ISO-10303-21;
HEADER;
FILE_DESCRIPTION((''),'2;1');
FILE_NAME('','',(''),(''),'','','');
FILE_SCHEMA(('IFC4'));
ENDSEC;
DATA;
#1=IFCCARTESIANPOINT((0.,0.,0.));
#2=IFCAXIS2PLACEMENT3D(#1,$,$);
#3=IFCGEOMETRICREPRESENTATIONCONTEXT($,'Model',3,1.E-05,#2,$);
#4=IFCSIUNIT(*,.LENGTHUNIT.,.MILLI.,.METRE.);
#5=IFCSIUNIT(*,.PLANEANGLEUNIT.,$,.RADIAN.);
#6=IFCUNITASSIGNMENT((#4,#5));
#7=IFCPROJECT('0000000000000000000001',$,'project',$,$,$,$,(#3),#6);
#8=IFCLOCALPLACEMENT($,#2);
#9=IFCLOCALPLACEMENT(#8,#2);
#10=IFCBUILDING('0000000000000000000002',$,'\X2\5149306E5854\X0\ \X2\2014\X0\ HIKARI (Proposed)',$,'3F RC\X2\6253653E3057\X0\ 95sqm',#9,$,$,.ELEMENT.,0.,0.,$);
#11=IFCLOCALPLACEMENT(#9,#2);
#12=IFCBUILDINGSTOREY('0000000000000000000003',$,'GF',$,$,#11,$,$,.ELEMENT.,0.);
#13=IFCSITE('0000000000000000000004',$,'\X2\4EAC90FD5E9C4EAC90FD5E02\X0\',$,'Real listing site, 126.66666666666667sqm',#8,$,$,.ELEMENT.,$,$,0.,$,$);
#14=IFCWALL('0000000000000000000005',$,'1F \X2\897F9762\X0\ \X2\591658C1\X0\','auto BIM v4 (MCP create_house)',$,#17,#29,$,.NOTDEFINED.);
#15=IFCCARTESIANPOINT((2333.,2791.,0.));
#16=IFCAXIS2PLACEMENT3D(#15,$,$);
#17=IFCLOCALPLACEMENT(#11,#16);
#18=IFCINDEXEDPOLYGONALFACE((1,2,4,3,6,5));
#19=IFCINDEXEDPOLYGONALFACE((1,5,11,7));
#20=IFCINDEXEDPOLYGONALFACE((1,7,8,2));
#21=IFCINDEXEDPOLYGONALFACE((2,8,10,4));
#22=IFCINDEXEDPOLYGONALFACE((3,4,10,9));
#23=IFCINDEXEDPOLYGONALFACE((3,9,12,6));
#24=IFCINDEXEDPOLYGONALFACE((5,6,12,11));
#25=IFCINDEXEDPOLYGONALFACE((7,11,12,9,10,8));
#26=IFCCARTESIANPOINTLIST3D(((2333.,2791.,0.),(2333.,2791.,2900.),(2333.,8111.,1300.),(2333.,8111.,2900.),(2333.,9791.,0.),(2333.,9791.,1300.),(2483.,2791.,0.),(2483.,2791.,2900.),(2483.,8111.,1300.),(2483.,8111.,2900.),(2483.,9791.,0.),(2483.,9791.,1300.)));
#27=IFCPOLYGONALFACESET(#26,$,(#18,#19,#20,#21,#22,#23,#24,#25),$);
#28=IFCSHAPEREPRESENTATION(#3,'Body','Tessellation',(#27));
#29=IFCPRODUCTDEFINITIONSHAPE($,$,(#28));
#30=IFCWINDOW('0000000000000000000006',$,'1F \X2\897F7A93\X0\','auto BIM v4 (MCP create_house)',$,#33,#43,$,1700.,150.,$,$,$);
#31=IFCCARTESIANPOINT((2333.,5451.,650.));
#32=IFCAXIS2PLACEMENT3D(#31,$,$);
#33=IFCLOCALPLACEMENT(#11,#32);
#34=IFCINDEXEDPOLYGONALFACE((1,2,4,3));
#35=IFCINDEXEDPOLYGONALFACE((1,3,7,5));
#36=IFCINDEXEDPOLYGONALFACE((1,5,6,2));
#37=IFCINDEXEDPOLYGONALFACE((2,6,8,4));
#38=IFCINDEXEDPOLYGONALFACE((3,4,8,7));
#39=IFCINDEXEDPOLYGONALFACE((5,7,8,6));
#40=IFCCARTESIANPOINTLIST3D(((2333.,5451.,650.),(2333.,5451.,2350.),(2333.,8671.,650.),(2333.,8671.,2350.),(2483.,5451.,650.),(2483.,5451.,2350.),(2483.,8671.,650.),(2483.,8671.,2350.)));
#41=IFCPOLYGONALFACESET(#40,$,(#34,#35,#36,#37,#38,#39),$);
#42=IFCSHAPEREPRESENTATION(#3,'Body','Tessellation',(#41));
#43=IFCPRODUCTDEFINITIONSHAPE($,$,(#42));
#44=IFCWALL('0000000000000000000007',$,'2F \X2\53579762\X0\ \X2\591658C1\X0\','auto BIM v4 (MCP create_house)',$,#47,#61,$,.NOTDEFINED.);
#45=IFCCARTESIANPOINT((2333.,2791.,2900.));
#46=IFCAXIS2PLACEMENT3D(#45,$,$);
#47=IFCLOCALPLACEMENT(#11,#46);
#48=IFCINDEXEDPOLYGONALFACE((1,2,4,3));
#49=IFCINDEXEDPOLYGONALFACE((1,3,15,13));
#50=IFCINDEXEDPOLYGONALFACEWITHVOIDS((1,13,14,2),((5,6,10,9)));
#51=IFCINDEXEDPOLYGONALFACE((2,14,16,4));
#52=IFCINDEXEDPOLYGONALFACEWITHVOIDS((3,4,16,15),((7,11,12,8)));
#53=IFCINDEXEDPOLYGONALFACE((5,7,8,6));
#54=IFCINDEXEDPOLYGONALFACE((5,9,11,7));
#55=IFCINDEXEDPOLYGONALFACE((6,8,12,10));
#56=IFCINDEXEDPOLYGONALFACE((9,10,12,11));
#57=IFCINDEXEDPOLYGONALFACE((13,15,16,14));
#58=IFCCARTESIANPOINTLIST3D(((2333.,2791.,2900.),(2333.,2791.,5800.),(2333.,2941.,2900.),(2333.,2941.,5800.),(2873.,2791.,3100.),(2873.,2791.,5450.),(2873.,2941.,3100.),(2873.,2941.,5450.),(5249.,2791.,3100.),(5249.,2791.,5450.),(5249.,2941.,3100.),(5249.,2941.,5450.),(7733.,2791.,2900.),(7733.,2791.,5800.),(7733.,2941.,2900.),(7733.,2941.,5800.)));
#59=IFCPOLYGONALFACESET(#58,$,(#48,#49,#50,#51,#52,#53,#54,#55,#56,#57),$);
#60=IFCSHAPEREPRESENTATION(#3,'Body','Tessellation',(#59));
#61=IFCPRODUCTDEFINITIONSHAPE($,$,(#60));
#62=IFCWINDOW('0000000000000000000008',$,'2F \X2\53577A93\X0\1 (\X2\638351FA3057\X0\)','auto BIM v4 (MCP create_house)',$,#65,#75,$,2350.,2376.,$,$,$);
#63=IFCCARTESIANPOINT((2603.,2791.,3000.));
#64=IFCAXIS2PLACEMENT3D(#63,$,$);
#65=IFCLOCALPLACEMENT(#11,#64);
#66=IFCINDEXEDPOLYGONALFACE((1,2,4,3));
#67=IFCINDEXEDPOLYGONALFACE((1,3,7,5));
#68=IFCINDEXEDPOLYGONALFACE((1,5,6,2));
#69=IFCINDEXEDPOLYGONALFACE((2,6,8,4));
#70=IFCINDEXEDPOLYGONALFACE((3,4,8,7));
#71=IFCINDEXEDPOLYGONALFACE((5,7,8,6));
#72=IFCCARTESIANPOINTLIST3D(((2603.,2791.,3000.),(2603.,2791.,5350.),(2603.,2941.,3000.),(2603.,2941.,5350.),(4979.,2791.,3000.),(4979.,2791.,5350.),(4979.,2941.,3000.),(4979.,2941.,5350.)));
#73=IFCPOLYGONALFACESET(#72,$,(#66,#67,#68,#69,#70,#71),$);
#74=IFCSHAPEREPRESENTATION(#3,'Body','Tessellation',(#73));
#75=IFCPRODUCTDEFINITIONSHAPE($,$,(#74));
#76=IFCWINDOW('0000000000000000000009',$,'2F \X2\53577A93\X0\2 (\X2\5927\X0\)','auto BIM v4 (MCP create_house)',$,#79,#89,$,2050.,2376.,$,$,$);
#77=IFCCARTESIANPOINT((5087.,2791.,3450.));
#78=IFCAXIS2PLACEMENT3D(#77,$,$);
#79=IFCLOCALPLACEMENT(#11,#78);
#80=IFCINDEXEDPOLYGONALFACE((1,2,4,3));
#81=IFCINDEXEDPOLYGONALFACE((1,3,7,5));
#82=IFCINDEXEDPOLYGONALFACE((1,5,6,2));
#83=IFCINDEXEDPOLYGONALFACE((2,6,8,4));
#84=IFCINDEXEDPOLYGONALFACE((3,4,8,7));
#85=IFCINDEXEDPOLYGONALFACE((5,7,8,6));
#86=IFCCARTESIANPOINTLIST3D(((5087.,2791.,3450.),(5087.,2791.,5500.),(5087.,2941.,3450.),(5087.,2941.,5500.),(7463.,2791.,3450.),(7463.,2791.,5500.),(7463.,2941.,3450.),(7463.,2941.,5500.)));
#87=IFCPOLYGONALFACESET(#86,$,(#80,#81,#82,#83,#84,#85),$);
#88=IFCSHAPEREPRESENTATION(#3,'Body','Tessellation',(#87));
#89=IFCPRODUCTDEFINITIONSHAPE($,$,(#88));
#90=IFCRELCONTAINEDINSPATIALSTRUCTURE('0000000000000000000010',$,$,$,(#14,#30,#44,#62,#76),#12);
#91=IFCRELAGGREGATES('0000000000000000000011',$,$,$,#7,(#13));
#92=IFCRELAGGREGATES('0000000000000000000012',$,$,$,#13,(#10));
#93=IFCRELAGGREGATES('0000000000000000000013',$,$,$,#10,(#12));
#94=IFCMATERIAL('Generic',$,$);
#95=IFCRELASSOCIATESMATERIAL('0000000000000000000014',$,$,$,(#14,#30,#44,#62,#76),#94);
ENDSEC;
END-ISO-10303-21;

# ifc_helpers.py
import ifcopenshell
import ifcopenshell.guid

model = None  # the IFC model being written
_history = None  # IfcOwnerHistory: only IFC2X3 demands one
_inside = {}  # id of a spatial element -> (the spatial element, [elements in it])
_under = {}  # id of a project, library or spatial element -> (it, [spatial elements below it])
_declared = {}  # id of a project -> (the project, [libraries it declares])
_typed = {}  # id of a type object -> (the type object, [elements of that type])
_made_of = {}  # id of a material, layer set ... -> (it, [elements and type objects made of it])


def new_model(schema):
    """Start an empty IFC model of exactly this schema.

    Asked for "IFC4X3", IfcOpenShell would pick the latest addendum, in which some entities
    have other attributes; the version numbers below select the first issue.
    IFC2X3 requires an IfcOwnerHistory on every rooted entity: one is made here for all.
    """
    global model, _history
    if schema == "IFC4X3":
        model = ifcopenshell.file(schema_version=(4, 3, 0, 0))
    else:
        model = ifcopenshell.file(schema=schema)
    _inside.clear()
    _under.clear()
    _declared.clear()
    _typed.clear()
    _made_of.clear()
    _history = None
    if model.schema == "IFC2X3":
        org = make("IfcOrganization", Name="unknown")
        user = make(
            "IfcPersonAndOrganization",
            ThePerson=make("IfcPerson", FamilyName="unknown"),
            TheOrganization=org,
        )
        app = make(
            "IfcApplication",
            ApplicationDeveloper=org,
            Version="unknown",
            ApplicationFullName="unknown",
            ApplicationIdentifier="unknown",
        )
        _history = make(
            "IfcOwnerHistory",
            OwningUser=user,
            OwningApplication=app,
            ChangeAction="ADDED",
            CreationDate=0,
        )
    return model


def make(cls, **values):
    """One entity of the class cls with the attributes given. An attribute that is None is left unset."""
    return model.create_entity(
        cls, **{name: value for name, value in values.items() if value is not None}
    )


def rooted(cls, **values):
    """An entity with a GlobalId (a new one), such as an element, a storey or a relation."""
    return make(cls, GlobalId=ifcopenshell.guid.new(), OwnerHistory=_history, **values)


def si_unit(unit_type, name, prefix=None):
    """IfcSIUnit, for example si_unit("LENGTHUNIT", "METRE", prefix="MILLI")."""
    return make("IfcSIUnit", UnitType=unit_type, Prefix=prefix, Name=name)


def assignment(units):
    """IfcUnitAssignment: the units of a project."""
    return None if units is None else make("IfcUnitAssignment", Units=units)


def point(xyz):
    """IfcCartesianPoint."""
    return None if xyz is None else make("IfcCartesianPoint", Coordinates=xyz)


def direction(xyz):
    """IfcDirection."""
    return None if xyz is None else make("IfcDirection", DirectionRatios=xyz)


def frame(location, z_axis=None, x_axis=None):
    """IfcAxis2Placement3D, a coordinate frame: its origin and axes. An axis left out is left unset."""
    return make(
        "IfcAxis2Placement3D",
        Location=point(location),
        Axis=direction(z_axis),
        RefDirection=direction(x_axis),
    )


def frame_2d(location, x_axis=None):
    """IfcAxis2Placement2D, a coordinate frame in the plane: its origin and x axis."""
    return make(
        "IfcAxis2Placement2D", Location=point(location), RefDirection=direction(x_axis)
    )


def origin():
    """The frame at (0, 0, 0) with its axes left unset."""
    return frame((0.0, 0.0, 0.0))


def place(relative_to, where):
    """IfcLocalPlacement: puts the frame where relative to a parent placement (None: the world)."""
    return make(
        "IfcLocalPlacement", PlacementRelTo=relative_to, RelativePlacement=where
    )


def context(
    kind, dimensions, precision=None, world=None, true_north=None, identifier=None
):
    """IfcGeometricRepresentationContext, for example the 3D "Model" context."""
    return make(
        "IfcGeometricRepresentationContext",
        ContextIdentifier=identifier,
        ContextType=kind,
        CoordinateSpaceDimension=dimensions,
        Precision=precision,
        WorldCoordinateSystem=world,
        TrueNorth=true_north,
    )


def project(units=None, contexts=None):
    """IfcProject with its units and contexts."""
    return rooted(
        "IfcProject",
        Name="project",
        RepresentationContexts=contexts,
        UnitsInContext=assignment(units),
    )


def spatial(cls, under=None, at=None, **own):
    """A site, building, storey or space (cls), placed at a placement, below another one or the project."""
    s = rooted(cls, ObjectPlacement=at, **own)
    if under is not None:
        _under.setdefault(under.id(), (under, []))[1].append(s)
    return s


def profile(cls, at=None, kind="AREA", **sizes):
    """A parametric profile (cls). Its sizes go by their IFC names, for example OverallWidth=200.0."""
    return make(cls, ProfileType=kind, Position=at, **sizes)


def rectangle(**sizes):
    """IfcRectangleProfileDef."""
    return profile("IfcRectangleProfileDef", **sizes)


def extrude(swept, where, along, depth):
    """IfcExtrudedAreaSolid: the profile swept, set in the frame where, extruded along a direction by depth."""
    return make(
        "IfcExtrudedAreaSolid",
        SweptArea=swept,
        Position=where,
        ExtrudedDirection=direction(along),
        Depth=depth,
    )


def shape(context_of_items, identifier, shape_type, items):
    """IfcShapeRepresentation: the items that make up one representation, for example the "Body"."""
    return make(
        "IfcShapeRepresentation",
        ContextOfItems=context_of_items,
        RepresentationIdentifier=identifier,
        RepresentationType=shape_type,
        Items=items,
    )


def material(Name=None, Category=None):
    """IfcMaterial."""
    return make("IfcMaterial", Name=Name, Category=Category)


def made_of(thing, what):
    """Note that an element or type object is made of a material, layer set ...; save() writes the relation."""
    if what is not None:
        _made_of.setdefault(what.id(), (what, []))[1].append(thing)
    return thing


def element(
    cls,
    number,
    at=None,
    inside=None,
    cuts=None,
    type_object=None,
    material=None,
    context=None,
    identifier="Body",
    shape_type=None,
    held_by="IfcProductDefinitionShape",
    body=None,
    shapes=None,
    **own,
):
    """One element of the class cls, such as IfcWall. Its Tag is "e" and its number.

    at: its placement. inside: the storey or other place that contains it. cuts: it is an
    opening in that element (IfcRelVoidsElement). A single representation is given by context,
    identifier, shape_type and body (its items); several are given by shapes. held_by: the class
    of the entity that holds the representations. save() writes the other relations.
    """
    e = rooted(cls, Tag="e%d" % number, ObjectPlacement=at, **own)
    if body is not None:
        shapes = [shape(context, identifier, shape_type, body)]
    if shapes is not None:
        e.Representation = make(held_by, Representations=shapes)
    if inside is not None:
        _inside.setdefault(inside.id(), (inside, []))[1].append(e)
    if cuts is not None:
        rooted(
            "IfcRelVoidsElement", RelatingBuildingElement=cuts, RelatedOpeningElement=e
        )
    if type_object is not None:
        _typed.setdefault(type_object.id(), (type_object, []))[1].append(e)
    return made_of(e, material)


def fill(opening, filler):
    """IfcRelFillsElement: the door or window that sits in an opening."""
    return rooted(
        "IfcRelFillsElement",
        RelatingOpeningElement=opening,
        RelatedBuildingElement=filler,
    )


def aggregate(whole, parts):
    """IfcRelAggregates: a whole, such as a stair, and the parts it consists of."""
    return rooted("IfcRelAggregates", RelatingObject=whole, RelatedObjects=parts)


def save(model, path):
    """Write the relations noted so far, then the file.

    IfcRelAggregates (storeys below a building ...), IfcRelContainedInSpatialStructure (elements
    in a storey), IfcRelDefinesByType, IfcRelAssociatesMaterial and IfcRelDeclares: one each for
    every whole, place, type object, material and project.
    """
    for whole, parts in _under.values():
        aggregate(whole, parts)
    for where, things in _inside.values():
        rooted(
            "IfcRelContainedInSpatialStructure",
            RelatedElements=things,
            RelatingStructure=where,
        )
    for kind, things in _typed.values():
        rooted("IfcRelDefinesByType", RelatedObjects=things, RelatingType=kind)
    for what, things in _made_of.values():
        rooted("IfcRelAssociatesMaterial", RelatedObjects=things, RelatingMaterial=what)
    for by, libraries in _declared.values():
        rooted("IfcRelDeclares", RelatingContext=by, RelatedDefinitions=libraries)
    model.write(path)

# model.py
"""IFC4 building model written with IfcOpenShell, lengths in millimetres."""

from ifc_helpers import new_model, si_unit, frame, frame_2d, origin, place, context, project, spatial, rectangle, extrude, material, element, fill, save


model = new_model("IFC4")

# Units and contexts
model_context = context("Model", 3, precision=1e-05, world=origin())
ifc_project = project(units=[si_unit("LENGTHUNIT", "METRE", prefix="MILLI"), si_unit("PLANEANGLEUNIT", "RADIAN")], contexts=[model_context])

# Site, building, storey
site_placement = place(None, origin())
site = spatial("IfcSite", under=ifc_project, at=site_placement, Name="京都府京都市", ObjectType="Real listing site, 126.66666666666667sqm", CompositionType="ELEMENT", RefElevation=0.0)
building_placement = place(site_placement, origin())
building = spatial("IfcBuilding", under=site, at=building_placement, Name="光の塔 — HIKARI (Proposed)", ObjectType="3F RC打放し 95sqm", CompositionType="ELEMENT", ElevationOfRefHeight=0.0, ElevationOfTerrain=0.0)
storey_placement = place(building_placement, origin())
storey = spatial("IfcBuildingStorey", under=building, at=storey_placement, Name="GF", CompositionType="ELEMENT", Elevation=0.0)

# Shared definitions
ifc_material = material(Name="Generic")

# Wall, opening, window
wall_1_placement = place(storey_placement, frame((2333.0, 2791.0, 0.0)))
wall_1 = element("IfcWall", 1, at=wall_1_placement, inside=storey, material=ifc_material, Name="1F 西面 外壁", Description="auto BIM v4 (MCP create_house)", PredefinedType="NOTDEFINED", context=model_context, shape_type="SweptSolid", body=[
    extrude(rectangle(XDim=150.0, YDim=7000.0, at=frame_2d((75.0, 3500.0))), frame((2333.0, 2791.0, 0.0)), (0.0, 0.0, 1.0), 2900.0),
])
opening_1_placement = place(storey_placement, frame((2333.0, 5451.0, 650.0)))
opening_1 = element("IfcOpeningElement", 2, at=opening_1_placement, cuts=wall_1, PredefinedType="NOTDEFINED", context=model_context, shape_type="SweptSolid", body=[
    extrude(rectangle(XDim=150.0, YDim=3220.0, at=frame_2d((75.0, 1610.0))), frame((2333.0, 5451.0, 650.0)), (0.0, 0.0, 1.0), 1700.0),
])
window_1_placement = place(storey_placement, frame((2333.0, 5451.0, 650.0)))
window_1 = element("IfcWindow", 3, at=window_1_placement, inside=storey, material=ifc_material, Name="1F 西窓", Description="auto BIM v4 (MCP create_house)", OverallHeight=1700.0, OverallWidth=150.0, context=model_context, shape_type="SweptSolid", body=[
    extrude(rectangle(XDim=150.0, YDim=3220.0, at=frame_2d((75.0, 1610.0))), frame((2333.0, 5451.0, 650.0)), (0.0, 0.0, 1.0), 1700.0),
])
fill(opening_1, window_1)

# Wall, openings, windows
wall_2_placement = place(storey_placement, frame((2333.0, 2791.0, 2900.0)))
wall_2 = element("IfcWall", 4, at=wall_2_placement, inside=storey, material=ifc_material, Name="2F 南面 外壁", Description="auto BIM v4 (MCP create_house)", PredefinedType="NOTDEFINED", context=model_context, shape_type="SweptSolid", body=[
    extrude(rectangle(XDim=5400.0, YDim=150.0, at=frame_2d((2700.0, 75.0))), frame((2333.0, 2791.0, 2900.0)), (0.0, 0.0, 1.0), 2900.0),
])
opening_2_placement = place(storey_placement, frame((2603.0, 2791.0, 3000.0)))
opening_2 = element("IfcOpeningElement", 5, at=opening_2_placement, cuts=wall_2, PredefinedType="NOTDEFINED", context=model_context, shape_type="SweptSolid", body=[
    extrude(rectangle(XDim=2376.0, YDim=150.0, at=frame_2d((1188.0, 75.0))), frame((2603.0, 2791.0, 3000.0)), (0.0, 0.0, 1.0), 2350.0),
])
opening_3_placement = place(storey_placement, frame((5087.0, 2791.0, 3450.0)))
opening_3 = element("IfcOpeningElement", 6, at=opening_3_placement, cuts=wall_2, PredefinedType="NOTDEFINED", context=model_context, shape_type="SweptSolid", body=[
    extrude(rectangle(XDim=2376.0, YDim=150.0, at=frame_2d((1188.0, 75.0))), frame((5087.0, 2791.0, 3450.0)), (0.0, 0.0, 1.0), 2050.0),
])
window_2_placement = place(storey_placement, frame((2603.0, 2791.0, 3000.0)))
window_2 = element("IfcWindow", 7, at=window_2_placement, inside=storey, material=ifc_material, Name="2F 南窓1 (掃出し)", Description="auto BIM v4 (MCP create_house)", OverallHeight=2350.0, OverallWidth=2376.0, context=model_context, shape_type="SweptSolid", body=[
    extrude(rectangle(XDim=2376.0, YDim=150.0, at=frame_2d((1188.0, 75.0))), frame((2603.0, 2791.0, 3000.0)), (0.0, 0.0, 1.0), 2350.0),
])
fill(opening_2, window_2)
window_3_placement = place(storey_placement, frame((5087.0, 2791.0, 3450.0)))
window_3 = element("IfcWindow", 8, at=window_3_placement, inside=storey, material=ifc_material, Name="2F 南窓2 (大)", Description="auto BIM v4 (MCP create_house)", OverallHeight=2050.0, OverallWidth=2376.0, context=model_context, shape_type="SweptSolid", body=[
    extrude(rectangle(XDim=2376.0, YDim=150.0, at=frame_2d((1188.0, 75.0))), frame((5087.0, 2791.0, 3450.0)), (0.0, 0.0, 1.0), 2050.0),
])
fill(opening_3, window_3)

save(model, "model.ifc")
